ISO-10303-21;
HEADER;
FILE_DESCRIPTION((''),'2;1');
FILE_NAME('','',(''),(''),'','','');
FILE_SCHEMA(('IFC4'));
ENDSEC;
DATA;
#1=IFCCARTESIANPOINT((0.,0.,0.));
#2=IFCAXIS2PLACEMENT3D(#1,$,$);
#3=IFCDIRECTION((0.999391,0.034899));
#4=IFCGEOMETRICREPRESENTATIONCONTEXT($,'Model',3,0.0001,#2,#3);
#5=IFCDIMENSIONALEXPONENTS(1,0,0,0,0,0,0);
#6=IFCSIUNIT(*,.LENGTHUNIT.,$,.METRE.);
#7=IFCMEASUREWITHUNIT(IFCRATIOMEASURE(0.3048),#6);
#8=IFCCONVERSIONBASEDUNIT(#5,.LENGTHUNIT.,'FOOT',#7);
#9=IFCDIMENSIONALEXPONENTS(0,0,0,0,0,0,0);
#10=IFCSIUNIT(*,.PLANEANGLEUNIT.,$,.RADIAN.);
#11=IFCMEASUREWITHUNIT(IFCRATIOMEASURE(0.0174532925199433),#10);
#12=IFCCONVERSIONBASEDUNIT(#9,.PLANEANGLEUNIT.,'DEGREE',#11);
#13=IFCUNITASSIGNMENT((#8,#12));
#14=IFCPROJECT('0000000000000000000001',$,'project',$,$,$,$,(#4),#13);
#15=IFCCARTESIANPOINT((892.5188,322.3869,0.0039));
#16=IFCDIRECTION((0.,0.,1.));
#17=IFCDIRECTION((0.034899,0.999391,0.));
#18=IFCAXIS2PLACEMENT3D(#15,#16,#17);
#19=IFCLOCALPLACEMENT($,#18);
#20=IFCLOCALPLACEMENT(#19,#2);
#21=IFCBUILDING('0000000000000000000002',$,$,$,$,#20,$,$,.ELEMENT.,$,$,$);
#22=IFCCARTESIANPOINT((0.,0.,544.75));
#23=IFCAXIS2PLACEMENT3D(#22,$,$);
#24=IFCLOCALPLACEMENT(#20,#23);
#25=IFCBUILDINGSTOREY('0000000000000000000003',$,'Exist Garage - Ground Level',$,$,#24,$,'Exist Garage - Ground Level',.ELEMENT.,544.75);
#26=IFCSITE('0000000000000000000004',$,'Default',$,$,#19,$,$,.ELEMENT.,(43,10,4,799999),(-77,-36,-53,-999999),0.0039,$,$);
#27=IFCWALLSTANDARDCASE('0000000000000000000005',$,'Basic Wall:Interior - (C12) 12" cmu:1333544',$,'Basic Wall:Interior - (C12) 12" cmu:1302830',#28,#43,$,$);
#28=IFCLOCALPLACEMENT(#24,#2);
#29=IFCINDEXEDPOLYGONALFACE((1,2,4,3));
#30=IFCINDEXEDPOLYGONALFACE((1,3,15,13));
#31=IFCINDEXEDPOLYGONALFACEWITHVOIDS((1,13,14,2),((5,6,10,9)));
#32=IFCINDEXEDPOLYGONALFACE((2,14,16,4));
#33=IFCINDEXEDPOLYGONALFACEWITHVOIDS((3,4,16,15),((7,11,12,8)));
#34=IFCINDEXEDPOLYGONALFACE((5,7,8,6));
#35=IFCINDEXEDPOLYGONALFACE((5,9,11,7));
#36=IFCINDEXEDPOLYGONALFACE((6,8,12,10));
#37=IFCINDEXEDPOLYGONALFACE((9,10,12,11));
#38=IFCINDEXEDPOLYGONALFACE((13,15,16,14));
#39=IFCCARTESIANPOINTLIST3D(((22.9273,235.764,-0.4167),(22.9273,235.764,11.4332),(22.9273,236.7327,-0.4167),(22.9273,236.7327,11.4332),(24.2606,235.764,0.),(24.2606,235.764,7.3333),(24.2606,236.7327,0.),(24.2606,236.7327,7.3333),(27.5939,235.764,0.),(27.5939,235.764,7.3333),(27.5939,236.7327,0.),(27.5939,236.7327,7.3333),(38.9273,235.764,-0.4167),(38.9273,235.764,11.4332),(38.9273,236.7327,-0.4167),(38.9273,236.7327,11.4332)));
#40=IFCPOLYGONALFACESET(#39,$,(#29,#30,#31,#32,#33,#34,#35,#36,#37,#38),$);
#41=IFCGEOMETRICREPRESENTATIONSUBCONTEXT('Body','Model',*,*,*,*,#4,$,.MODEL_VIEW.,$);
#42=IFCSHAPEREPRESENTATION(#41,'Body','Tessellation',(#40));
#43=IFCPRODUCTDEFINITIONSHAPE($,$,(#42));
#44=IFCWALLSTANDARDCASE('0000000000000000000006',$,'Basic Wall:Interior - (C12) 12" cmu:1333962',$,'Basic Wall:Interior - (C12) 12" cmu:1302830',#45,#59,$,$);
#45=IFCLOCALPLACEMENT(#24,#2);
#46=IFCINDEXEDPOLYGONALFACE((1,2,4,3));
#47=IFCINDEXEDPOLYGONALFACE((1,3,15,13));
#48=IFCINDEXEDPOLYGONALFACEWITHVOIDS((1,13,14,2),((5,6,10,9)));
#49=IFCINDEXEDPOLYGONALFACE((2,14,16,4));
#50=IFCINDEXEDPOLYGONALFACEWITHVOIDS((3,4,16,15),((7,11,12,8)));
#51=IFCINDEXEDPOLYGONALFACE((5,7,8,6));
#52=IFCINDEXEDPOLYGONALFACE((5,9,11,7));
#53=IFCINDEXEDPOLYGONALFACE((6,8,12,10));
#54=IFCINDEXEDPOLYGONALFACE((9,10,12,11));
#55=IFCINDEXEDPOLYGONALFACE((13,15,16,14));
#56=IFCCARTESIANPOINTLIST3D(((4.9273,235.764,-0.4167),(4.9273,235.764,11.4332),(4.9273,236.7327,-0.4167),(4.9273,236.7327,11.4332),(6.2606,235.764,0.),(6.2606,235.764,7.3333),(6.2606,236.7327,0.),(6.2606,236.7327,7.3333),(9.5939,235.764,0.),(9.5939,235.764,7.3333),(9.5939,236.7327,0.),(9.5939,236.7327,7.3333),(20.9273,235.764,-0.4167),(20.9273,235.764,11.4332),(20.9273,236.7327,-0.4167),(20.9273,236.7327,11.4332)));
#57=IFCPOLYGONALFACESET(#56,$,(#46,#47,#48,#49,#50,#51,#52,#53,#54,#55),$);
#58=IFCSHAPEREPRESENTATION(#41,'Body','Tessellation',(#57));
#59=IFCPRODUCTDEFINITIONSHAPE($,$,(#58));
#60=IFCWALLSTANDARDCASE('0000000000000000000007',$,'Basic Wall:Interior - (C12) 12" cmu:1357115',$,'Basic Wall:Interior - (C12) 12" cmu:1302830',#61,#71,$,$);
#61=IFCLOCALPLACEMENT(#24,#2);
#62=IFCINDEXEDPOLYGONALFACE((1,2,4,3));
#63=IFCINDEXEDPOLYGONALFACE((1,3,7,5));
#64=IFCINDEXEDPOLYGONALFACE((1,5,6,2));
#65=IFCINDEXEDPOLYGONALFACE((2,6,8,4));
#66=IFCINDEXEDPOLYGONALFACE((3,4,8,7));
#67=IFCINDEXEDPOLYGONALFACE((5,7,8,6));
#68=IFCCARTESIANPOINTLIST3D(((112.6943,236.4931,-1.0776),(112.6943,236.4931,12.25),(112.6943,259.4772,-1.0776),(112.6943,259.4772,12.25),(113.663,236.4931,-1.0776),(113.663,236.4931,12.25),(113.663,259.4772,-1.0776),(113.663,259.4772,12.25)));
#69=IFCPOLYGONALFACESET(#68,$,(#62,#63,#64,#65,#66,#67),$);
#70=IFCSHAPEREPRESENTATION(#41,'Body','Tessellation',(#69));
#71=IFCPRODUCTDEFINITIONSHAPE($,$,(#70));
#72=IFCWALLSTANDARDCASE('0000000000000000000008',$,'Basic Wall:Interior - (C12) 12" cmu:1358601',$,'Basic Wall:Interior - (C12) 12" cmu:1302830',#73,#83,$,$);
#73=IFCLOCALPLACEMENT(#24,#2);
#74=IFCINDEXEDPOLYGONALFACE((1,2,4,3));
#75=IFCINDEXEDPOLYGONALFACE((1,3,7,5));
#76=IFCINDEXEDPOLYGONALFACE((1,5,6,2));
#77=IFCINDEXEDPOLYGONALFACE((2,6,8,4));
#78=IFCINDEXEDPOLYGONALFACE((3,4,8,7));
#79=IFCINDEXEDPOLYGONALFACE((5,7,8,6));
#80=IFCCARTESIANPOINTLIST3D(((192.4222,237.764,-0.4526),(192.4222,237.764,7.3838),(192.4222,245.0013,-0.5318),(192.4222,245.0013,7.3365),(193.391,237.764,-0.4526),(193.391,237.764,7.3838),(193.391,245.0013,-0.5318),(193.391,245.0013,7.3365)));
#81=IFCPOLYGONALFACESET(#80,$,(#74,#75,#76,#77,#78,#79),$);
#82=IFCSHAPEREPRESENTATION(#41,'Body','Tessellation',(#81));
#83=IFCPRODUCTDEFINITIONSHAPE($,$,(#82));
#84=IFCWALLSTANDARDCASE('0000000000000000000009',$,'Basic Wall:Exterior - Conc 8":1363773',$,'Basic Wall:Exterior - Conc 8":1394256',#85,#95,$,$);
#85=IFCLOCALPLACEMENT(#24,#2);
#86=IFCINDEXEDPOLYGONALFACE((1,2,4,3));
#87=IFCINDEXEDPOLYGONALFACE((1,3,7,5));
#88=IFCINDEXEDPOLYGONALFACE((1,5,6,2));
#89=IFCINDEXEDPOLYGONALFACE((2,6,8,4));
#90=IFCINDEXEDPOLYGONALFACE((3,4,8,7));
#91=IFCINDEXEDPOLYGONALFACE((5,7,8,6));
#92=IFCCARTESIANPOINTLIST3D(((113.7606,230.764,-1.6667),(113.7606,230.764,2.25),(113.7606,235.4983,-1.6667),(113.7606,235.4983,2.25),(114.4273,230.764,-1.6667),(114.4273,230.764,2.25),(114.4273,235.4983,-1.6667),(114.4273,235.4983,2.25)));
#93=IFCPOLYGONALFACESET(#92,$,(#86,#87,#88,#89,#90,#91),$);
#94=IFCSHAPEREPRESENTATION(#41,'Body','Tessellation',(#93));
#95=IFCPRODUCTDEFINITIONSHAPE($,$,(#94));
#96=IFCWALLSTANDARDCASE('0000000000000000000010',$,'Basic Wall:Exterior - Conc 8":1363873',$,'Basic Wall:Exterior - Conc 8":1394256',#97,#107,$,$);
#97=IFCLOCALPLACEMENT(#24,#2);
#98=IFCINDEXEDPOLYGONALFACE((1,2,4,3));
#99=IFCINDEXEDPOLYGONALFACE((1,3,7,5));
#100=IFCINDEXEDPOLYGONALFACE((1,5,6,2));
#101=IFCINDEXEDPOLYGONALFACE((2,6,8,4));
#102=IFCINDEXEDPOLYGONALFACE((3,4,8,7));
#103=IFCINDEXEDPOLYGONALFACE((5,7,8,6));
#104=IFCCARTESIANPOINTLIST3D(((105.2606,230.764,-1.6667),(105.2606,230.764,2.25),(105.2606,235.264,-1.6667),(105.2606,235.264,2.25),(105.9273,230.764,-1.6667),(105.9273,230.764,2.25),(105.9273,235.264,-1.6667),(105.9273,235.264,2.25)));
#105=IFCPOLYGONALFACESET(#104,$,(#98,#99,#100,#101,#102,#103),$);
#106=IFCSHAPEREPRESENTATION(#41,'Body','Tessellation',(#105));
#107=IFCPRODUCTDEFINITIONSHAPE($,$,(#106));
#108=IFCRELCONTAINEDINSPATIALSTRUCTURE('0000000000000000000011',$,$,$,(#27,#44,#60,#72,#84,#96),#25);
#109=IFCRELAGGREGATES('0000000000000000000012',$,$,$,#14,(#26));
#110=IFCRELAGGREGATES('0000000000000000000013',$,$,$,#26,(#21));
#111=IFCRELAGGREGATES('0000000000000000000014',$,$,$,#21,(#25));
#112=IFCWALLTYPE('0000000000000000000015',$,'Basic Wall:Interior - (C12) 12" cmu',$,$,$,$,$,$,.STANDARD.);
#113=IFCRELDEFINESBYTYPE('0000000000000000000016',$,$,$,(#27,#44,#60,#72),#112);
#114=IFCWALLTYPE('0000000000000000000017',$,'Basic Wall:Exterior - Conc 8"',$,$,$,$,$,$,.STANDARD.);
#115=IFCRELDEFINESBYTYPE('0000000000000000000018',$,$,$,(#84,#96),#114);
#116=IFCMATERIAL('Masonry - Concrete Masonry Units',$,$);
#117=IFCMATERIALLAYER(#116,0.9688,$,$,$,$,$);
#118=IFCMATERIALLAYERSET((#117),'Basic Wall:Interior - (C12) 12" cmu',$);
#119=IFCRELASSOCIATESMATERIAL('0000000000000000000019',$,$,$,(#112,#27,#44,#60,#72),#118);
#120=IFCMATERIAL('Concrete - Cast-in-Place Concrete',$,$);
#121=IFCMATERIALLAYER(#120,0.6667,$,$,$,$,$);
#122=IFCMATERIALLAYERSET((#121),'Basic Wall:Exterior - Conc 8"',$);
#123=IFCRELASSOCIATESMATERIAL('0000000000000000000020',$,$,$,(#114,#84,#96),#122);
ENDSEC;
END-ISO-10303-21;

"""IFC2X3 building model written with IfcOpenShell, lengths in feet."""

from ifc_helpers import new_model, entity, si_unit, converted_unit, direction, frame, frame_2d, origin, place, context, subcontext, project, spatial, rectangle, extrude, clip, halfspace, material, layer, layer_set, layer_usage, type_object, element, save


model = new_model("IFC2X3")

# Units and contexts
model_context = context("Model", 3, precision=0.0001, world=origin(), true_north=direction((0.999391, 0.034899)))
body_context = subcontext(model_context, "Body", "Model", "MODEL_VIEW")
ifc_project = project(units=[converted_unit("LENGTHUNIT", "FOOT", entity("IfcRatioMeasure", 0.3048), si_unit("LENGTHUNIT", "METRE"), dimensions=[1, 0, 0, 0, 0, 0, 0]), converted_unit("PLANEANGLEUNIT", "DEGREE", entity("IfcRatioMeasure", 0.0174532925199433), si_unit("PLANEANGLEUNIT", "RADIAN"), dimensions=[0, 0, 0, 0, 0, 0, 0])], contexts=[model_context])

# Site, building, storey
site_placement = place(None, frame((892.5188, 322.3869, 0.0039), z_axis=(0.0, 0.0, 1.0), x_axis=(0.034899, 0.999391, 0.0)))
site = spatial("IfcSite", under=ifc_project, at=site_placement, Name="Default", CompositionType="ELEMENT", RefLatitude=(43, 10, 4, 799999), RefLongitude=(-77, -36, -53, -999999), RefElevation=0.0039)
building_placement = place(site_placement, origin())
building = spatial("IfcBuilding", under=site, at=building_placement, CompositionType="ELEMENT")
storey_placement = place(building_placement, frame((0.0, 0.0, 544.75)))
storey = spatial("IfcBuildingStorey", under=building, at=storey_placement, Name="Exist Garage - Ground Level", LongName="Exist Garage - Ground Level", CompositionType="ELEMENT", Elevation=544.75)

# Shared definitions
ifc_material_1 = material(Name="Concrete - Cast-in-Place Concrete")

# Walls, openings
ifc_material_2 = material(Name="Masonry - Concrete Masonry Units")
ifc_layer_1 = layer(ifc_material_2, 0.9688)
ifc_layer_set_1 = layer_set([ifc_layer_1], Name="Basic Wall:Interior - (C12) 12\" cmu")
wall_type_1 = type_object("IfcWallType", Name="Basic Wall:Interior - (C12) 12\" cmu", PredefinedType="STANDARD", material=ifc_layer_set_1)
ifc_layer_usage_1 = layer_usage(ifc_layer_set_1, "AXIS2", "POSITIVE", -0.4844)
wall_1_placement = place(storey_placement, frame((22.9273, 236.2483, -0.4167)))
wall_1 = element("IfcWallStandardCase", 1, at=wall_1_placement, inside=storey, type_object=wall_type_1, material=ifc_layer_usage_1, Name="Basic Wall:Interior - (C12) 12\" cmu:1333544", ObjectType="Basic Wall:Interior - (C12) 12\" cmu:1302830", context=body_context, shape_type="SweptSolid", body=[
    extrude(rectangle(XDim=16.0, YDim=0.9688, at=frame_2d((8.0, 0.0), x_axis=(-1.0, 0.0))), origin(), (0.0, 0.0, 1.0), 11.8498),
])
opening_1_placement = place(wall_1_placement, frame((1.3333, -0.4844, 0.4167)))
element("IfcOpeningElement", 2, at=opening_1_placement, cuts=wall_1, ObjectType="Opening", context=body_context, shape_type="SweptSolid", body=[
    extrude(rectangle(XDim=3.3333, YDim=7.3333, at=frame_2d((3.6667, 1.6667), x_axis=(0.0, -1.0))), frame((0.0, 0.0, 0.0), z_axis=(0.0, 1.0, 0.0), x_axis=(0.0, 0.0, 1.0)), (0.0, 0.0, 1.0), 0.9688),
])
ifc_layer_usage_2 = layer_usage(ifc_layer_set_1, "AXIS2", "NEGATIVE", 0.4844)
wall_2_placement = place(storey_placement, frame((20.9273, 236.2483, -0.4167), z_axis=(0.0, 0.0, 1.0), x_axis=(-1.0, 0.0, 0.0)))
wall_2 = element("IfcWallStandardCase", 3, at=wall_2_placement, inside=storey, type_object=wall_type_1, material=ifc_layer_usage_2, Name="Basic Wall:Interior - (C12) 12\" cmu:1333962", ObjectType="Basic Wall:Interior - (C12) 12\" cmu:1302830", context=body_context, shape_type="SweptSolid", body=[
    extrude(rectangle(XDim=16.0, YDim=0.9688, at=frame_2d((8.0, 0.0), x_axis=(-1.0, 0.0))), origin(), (0.0, 0.0, 1.0), 11.8498),
])
opening_2_placement = place(wall_2_placement, frame((14.6667, 0.4844, 0.4167)))
element("IfcOpeningElement", 4, at=opening_2_placement, cuts=wall_2, ObjectType="Opening", context=body_context, shape_type="SweptSolid", body=[
    extrude(rectangle(XDim=3.3333, YDim=7.3333, at=frame_2d((3.6667, 1.6667), x_axis=(0.0, -1.0))), frame((0.0, 0.0, 0.0), z_axis=(0.0, -1.0, 0.0), x_axis=(0.0, 0.0, 1.0)), (0.0, 0.0, 1.0), 0.9688),
])

# Walls
ifc_layer_usage_3 = layer_usage(ifc_layer_set_1, "AXIS2", "NEGATIVE", 0.4844)
wall_3_placement = place(storey_placement, frame((113.1786, 236.4931, -1.0776), z_axis=(0.0, 0.0, 1.0), x_axis=(0.0, 1.0, 0.0)))
element("IfcWallStandardCase", 5, at=wall_3_placement, inside=storey, type_object=wall_type_1, material=ifc_layer_usage_3, Name="Basic Wall:Interior - (C12) 12\" cmu:1357115", ObjectType="Basic Wall:Interior - (C12) 12\" cmu:1302830", context=body_context, shape_type="SweptSolid", body=[
    extrude(rectangle(XDim=22.984, YDim=0.9688, at=frame_2d((11.492, 0.0), x_axis=(-1.0, 0.0))), origin(), (0.0, 0.0, 1.0), 13.3276),
])
ifc_layer_usage_4 = layer_usage(ifc_layer_set_1, "AXIS2", "NEGATIVE", 0.4844)
wall_4_placement = place(storey_placement, frame((192.9066, 237.764, -0.5318), z_axis=(0.0, 0.0, 1.0), x_axis=(0.0, 1.0, 0.0)))
element("IfcWallStandardCase", 6, at=wall_4_placement, inside=storey, type_object=wall_type_1, material=ifc_layer_usage_4, Name="Basic Wall:Interior - (C12) 12\" cmu:1358601", ObjectType="Basic Wall:Interior - (C12) 12\" cmu:1302830", context=body_context, shape_type="Clipping", body=[
    clip(clip(extrude(rectangle(XDim=7.2374, YDim=0.9688, at=frame_2d((3.6187, 0.0), x_axis=(-1.0, 0.0))), origin(), (0.0, 0.0, 1.0), 7.9156), halfspace(frame((7.2374, -0.4844, 0.0), z_axis=(-0.010943, 0.0, -0.99994), x_axis=(0.0, 1.0, 0.0)), False)), halfspace(frame((0.0, -0.4844, 7.9156), z_axis=(0.006532, 0.0, 0.999979), x_axis=(0.0, 1.0, 0.0)), False)),
])
ifc_layer_2 = layer(ifc_material_1, 0.6667)
ifc_layer_set_2 = layer_set([ifc_layer_2], Name="Basic Wall:Exterior - Conc 8\"")
ifc_layer_usage_5 = layer_usage(ifc_layer_set_2, "AXIS2", "NEGATIVE", 0.3333)
wall_type_2 = type_object("IfcWallType", Name="Basic Wall:Exterior - Conc 8\"", PredefinedType="STANDARD", material=ifc_layer_set_2)
wall_5_placement = place(storey_placement, frame((114.094, 235.4983, -1.6667), z_axis=(0.0, 0.0, 1.0), x_axis=(0.0, -1.0, 0.0)))
element("IfcWallStandardCase", 7, at=wall_5_placement, inside=storey, type_object=wall_type_2, material=ifc_layer_usage_5, Name="Basic Wall:Exterior - Conc 8\":1363773", ObjectType="Basic Wall:Exterior - Conc 8\":1394256", context=body_context, shape_type="SweptSolid", body=[
    extrude(rectangle(XDim=4.7344, YDim=0.6667, at=frame_2d((2.3672, 0.0), x_axis=(-1.0, 0.0))), origin(), (0.0, 0.0, 1.0), 3.9167),
])
ifc_layer_usage_6 = layer_usage(ifc_layer_set_2, "AXIS2", "NEGATIVE", 0.3333)
wall_6_placement = place(storey_placement, frame((105.594, 230.764, -1.6667), z_axis=(0.0, 0.0, 1.0), x_axis=(0.0, 1.0, 0.0)))
element("IfcWallStandardCase", 8, at=wall_6_placement, inside=storey, type_object=wall_type_2, material=ifc_layer_usage_6, Name="Basic Wall:Exterior - Conc 8\":1363873", ObjectType="Basic Wall:Exterior - Conc 8\":1394256", context=body_context, shape_type="SweptSolid", body=[
    extrude(rectangle(XDim=4.5, YDim=0.6667, at=frame_2d((2.25, 0.0), x_axis=(-1.0, 0.0))), origin(), (0.0, 0.0, 1.0), 3.9167),
])

save(model, "model.ifc")
